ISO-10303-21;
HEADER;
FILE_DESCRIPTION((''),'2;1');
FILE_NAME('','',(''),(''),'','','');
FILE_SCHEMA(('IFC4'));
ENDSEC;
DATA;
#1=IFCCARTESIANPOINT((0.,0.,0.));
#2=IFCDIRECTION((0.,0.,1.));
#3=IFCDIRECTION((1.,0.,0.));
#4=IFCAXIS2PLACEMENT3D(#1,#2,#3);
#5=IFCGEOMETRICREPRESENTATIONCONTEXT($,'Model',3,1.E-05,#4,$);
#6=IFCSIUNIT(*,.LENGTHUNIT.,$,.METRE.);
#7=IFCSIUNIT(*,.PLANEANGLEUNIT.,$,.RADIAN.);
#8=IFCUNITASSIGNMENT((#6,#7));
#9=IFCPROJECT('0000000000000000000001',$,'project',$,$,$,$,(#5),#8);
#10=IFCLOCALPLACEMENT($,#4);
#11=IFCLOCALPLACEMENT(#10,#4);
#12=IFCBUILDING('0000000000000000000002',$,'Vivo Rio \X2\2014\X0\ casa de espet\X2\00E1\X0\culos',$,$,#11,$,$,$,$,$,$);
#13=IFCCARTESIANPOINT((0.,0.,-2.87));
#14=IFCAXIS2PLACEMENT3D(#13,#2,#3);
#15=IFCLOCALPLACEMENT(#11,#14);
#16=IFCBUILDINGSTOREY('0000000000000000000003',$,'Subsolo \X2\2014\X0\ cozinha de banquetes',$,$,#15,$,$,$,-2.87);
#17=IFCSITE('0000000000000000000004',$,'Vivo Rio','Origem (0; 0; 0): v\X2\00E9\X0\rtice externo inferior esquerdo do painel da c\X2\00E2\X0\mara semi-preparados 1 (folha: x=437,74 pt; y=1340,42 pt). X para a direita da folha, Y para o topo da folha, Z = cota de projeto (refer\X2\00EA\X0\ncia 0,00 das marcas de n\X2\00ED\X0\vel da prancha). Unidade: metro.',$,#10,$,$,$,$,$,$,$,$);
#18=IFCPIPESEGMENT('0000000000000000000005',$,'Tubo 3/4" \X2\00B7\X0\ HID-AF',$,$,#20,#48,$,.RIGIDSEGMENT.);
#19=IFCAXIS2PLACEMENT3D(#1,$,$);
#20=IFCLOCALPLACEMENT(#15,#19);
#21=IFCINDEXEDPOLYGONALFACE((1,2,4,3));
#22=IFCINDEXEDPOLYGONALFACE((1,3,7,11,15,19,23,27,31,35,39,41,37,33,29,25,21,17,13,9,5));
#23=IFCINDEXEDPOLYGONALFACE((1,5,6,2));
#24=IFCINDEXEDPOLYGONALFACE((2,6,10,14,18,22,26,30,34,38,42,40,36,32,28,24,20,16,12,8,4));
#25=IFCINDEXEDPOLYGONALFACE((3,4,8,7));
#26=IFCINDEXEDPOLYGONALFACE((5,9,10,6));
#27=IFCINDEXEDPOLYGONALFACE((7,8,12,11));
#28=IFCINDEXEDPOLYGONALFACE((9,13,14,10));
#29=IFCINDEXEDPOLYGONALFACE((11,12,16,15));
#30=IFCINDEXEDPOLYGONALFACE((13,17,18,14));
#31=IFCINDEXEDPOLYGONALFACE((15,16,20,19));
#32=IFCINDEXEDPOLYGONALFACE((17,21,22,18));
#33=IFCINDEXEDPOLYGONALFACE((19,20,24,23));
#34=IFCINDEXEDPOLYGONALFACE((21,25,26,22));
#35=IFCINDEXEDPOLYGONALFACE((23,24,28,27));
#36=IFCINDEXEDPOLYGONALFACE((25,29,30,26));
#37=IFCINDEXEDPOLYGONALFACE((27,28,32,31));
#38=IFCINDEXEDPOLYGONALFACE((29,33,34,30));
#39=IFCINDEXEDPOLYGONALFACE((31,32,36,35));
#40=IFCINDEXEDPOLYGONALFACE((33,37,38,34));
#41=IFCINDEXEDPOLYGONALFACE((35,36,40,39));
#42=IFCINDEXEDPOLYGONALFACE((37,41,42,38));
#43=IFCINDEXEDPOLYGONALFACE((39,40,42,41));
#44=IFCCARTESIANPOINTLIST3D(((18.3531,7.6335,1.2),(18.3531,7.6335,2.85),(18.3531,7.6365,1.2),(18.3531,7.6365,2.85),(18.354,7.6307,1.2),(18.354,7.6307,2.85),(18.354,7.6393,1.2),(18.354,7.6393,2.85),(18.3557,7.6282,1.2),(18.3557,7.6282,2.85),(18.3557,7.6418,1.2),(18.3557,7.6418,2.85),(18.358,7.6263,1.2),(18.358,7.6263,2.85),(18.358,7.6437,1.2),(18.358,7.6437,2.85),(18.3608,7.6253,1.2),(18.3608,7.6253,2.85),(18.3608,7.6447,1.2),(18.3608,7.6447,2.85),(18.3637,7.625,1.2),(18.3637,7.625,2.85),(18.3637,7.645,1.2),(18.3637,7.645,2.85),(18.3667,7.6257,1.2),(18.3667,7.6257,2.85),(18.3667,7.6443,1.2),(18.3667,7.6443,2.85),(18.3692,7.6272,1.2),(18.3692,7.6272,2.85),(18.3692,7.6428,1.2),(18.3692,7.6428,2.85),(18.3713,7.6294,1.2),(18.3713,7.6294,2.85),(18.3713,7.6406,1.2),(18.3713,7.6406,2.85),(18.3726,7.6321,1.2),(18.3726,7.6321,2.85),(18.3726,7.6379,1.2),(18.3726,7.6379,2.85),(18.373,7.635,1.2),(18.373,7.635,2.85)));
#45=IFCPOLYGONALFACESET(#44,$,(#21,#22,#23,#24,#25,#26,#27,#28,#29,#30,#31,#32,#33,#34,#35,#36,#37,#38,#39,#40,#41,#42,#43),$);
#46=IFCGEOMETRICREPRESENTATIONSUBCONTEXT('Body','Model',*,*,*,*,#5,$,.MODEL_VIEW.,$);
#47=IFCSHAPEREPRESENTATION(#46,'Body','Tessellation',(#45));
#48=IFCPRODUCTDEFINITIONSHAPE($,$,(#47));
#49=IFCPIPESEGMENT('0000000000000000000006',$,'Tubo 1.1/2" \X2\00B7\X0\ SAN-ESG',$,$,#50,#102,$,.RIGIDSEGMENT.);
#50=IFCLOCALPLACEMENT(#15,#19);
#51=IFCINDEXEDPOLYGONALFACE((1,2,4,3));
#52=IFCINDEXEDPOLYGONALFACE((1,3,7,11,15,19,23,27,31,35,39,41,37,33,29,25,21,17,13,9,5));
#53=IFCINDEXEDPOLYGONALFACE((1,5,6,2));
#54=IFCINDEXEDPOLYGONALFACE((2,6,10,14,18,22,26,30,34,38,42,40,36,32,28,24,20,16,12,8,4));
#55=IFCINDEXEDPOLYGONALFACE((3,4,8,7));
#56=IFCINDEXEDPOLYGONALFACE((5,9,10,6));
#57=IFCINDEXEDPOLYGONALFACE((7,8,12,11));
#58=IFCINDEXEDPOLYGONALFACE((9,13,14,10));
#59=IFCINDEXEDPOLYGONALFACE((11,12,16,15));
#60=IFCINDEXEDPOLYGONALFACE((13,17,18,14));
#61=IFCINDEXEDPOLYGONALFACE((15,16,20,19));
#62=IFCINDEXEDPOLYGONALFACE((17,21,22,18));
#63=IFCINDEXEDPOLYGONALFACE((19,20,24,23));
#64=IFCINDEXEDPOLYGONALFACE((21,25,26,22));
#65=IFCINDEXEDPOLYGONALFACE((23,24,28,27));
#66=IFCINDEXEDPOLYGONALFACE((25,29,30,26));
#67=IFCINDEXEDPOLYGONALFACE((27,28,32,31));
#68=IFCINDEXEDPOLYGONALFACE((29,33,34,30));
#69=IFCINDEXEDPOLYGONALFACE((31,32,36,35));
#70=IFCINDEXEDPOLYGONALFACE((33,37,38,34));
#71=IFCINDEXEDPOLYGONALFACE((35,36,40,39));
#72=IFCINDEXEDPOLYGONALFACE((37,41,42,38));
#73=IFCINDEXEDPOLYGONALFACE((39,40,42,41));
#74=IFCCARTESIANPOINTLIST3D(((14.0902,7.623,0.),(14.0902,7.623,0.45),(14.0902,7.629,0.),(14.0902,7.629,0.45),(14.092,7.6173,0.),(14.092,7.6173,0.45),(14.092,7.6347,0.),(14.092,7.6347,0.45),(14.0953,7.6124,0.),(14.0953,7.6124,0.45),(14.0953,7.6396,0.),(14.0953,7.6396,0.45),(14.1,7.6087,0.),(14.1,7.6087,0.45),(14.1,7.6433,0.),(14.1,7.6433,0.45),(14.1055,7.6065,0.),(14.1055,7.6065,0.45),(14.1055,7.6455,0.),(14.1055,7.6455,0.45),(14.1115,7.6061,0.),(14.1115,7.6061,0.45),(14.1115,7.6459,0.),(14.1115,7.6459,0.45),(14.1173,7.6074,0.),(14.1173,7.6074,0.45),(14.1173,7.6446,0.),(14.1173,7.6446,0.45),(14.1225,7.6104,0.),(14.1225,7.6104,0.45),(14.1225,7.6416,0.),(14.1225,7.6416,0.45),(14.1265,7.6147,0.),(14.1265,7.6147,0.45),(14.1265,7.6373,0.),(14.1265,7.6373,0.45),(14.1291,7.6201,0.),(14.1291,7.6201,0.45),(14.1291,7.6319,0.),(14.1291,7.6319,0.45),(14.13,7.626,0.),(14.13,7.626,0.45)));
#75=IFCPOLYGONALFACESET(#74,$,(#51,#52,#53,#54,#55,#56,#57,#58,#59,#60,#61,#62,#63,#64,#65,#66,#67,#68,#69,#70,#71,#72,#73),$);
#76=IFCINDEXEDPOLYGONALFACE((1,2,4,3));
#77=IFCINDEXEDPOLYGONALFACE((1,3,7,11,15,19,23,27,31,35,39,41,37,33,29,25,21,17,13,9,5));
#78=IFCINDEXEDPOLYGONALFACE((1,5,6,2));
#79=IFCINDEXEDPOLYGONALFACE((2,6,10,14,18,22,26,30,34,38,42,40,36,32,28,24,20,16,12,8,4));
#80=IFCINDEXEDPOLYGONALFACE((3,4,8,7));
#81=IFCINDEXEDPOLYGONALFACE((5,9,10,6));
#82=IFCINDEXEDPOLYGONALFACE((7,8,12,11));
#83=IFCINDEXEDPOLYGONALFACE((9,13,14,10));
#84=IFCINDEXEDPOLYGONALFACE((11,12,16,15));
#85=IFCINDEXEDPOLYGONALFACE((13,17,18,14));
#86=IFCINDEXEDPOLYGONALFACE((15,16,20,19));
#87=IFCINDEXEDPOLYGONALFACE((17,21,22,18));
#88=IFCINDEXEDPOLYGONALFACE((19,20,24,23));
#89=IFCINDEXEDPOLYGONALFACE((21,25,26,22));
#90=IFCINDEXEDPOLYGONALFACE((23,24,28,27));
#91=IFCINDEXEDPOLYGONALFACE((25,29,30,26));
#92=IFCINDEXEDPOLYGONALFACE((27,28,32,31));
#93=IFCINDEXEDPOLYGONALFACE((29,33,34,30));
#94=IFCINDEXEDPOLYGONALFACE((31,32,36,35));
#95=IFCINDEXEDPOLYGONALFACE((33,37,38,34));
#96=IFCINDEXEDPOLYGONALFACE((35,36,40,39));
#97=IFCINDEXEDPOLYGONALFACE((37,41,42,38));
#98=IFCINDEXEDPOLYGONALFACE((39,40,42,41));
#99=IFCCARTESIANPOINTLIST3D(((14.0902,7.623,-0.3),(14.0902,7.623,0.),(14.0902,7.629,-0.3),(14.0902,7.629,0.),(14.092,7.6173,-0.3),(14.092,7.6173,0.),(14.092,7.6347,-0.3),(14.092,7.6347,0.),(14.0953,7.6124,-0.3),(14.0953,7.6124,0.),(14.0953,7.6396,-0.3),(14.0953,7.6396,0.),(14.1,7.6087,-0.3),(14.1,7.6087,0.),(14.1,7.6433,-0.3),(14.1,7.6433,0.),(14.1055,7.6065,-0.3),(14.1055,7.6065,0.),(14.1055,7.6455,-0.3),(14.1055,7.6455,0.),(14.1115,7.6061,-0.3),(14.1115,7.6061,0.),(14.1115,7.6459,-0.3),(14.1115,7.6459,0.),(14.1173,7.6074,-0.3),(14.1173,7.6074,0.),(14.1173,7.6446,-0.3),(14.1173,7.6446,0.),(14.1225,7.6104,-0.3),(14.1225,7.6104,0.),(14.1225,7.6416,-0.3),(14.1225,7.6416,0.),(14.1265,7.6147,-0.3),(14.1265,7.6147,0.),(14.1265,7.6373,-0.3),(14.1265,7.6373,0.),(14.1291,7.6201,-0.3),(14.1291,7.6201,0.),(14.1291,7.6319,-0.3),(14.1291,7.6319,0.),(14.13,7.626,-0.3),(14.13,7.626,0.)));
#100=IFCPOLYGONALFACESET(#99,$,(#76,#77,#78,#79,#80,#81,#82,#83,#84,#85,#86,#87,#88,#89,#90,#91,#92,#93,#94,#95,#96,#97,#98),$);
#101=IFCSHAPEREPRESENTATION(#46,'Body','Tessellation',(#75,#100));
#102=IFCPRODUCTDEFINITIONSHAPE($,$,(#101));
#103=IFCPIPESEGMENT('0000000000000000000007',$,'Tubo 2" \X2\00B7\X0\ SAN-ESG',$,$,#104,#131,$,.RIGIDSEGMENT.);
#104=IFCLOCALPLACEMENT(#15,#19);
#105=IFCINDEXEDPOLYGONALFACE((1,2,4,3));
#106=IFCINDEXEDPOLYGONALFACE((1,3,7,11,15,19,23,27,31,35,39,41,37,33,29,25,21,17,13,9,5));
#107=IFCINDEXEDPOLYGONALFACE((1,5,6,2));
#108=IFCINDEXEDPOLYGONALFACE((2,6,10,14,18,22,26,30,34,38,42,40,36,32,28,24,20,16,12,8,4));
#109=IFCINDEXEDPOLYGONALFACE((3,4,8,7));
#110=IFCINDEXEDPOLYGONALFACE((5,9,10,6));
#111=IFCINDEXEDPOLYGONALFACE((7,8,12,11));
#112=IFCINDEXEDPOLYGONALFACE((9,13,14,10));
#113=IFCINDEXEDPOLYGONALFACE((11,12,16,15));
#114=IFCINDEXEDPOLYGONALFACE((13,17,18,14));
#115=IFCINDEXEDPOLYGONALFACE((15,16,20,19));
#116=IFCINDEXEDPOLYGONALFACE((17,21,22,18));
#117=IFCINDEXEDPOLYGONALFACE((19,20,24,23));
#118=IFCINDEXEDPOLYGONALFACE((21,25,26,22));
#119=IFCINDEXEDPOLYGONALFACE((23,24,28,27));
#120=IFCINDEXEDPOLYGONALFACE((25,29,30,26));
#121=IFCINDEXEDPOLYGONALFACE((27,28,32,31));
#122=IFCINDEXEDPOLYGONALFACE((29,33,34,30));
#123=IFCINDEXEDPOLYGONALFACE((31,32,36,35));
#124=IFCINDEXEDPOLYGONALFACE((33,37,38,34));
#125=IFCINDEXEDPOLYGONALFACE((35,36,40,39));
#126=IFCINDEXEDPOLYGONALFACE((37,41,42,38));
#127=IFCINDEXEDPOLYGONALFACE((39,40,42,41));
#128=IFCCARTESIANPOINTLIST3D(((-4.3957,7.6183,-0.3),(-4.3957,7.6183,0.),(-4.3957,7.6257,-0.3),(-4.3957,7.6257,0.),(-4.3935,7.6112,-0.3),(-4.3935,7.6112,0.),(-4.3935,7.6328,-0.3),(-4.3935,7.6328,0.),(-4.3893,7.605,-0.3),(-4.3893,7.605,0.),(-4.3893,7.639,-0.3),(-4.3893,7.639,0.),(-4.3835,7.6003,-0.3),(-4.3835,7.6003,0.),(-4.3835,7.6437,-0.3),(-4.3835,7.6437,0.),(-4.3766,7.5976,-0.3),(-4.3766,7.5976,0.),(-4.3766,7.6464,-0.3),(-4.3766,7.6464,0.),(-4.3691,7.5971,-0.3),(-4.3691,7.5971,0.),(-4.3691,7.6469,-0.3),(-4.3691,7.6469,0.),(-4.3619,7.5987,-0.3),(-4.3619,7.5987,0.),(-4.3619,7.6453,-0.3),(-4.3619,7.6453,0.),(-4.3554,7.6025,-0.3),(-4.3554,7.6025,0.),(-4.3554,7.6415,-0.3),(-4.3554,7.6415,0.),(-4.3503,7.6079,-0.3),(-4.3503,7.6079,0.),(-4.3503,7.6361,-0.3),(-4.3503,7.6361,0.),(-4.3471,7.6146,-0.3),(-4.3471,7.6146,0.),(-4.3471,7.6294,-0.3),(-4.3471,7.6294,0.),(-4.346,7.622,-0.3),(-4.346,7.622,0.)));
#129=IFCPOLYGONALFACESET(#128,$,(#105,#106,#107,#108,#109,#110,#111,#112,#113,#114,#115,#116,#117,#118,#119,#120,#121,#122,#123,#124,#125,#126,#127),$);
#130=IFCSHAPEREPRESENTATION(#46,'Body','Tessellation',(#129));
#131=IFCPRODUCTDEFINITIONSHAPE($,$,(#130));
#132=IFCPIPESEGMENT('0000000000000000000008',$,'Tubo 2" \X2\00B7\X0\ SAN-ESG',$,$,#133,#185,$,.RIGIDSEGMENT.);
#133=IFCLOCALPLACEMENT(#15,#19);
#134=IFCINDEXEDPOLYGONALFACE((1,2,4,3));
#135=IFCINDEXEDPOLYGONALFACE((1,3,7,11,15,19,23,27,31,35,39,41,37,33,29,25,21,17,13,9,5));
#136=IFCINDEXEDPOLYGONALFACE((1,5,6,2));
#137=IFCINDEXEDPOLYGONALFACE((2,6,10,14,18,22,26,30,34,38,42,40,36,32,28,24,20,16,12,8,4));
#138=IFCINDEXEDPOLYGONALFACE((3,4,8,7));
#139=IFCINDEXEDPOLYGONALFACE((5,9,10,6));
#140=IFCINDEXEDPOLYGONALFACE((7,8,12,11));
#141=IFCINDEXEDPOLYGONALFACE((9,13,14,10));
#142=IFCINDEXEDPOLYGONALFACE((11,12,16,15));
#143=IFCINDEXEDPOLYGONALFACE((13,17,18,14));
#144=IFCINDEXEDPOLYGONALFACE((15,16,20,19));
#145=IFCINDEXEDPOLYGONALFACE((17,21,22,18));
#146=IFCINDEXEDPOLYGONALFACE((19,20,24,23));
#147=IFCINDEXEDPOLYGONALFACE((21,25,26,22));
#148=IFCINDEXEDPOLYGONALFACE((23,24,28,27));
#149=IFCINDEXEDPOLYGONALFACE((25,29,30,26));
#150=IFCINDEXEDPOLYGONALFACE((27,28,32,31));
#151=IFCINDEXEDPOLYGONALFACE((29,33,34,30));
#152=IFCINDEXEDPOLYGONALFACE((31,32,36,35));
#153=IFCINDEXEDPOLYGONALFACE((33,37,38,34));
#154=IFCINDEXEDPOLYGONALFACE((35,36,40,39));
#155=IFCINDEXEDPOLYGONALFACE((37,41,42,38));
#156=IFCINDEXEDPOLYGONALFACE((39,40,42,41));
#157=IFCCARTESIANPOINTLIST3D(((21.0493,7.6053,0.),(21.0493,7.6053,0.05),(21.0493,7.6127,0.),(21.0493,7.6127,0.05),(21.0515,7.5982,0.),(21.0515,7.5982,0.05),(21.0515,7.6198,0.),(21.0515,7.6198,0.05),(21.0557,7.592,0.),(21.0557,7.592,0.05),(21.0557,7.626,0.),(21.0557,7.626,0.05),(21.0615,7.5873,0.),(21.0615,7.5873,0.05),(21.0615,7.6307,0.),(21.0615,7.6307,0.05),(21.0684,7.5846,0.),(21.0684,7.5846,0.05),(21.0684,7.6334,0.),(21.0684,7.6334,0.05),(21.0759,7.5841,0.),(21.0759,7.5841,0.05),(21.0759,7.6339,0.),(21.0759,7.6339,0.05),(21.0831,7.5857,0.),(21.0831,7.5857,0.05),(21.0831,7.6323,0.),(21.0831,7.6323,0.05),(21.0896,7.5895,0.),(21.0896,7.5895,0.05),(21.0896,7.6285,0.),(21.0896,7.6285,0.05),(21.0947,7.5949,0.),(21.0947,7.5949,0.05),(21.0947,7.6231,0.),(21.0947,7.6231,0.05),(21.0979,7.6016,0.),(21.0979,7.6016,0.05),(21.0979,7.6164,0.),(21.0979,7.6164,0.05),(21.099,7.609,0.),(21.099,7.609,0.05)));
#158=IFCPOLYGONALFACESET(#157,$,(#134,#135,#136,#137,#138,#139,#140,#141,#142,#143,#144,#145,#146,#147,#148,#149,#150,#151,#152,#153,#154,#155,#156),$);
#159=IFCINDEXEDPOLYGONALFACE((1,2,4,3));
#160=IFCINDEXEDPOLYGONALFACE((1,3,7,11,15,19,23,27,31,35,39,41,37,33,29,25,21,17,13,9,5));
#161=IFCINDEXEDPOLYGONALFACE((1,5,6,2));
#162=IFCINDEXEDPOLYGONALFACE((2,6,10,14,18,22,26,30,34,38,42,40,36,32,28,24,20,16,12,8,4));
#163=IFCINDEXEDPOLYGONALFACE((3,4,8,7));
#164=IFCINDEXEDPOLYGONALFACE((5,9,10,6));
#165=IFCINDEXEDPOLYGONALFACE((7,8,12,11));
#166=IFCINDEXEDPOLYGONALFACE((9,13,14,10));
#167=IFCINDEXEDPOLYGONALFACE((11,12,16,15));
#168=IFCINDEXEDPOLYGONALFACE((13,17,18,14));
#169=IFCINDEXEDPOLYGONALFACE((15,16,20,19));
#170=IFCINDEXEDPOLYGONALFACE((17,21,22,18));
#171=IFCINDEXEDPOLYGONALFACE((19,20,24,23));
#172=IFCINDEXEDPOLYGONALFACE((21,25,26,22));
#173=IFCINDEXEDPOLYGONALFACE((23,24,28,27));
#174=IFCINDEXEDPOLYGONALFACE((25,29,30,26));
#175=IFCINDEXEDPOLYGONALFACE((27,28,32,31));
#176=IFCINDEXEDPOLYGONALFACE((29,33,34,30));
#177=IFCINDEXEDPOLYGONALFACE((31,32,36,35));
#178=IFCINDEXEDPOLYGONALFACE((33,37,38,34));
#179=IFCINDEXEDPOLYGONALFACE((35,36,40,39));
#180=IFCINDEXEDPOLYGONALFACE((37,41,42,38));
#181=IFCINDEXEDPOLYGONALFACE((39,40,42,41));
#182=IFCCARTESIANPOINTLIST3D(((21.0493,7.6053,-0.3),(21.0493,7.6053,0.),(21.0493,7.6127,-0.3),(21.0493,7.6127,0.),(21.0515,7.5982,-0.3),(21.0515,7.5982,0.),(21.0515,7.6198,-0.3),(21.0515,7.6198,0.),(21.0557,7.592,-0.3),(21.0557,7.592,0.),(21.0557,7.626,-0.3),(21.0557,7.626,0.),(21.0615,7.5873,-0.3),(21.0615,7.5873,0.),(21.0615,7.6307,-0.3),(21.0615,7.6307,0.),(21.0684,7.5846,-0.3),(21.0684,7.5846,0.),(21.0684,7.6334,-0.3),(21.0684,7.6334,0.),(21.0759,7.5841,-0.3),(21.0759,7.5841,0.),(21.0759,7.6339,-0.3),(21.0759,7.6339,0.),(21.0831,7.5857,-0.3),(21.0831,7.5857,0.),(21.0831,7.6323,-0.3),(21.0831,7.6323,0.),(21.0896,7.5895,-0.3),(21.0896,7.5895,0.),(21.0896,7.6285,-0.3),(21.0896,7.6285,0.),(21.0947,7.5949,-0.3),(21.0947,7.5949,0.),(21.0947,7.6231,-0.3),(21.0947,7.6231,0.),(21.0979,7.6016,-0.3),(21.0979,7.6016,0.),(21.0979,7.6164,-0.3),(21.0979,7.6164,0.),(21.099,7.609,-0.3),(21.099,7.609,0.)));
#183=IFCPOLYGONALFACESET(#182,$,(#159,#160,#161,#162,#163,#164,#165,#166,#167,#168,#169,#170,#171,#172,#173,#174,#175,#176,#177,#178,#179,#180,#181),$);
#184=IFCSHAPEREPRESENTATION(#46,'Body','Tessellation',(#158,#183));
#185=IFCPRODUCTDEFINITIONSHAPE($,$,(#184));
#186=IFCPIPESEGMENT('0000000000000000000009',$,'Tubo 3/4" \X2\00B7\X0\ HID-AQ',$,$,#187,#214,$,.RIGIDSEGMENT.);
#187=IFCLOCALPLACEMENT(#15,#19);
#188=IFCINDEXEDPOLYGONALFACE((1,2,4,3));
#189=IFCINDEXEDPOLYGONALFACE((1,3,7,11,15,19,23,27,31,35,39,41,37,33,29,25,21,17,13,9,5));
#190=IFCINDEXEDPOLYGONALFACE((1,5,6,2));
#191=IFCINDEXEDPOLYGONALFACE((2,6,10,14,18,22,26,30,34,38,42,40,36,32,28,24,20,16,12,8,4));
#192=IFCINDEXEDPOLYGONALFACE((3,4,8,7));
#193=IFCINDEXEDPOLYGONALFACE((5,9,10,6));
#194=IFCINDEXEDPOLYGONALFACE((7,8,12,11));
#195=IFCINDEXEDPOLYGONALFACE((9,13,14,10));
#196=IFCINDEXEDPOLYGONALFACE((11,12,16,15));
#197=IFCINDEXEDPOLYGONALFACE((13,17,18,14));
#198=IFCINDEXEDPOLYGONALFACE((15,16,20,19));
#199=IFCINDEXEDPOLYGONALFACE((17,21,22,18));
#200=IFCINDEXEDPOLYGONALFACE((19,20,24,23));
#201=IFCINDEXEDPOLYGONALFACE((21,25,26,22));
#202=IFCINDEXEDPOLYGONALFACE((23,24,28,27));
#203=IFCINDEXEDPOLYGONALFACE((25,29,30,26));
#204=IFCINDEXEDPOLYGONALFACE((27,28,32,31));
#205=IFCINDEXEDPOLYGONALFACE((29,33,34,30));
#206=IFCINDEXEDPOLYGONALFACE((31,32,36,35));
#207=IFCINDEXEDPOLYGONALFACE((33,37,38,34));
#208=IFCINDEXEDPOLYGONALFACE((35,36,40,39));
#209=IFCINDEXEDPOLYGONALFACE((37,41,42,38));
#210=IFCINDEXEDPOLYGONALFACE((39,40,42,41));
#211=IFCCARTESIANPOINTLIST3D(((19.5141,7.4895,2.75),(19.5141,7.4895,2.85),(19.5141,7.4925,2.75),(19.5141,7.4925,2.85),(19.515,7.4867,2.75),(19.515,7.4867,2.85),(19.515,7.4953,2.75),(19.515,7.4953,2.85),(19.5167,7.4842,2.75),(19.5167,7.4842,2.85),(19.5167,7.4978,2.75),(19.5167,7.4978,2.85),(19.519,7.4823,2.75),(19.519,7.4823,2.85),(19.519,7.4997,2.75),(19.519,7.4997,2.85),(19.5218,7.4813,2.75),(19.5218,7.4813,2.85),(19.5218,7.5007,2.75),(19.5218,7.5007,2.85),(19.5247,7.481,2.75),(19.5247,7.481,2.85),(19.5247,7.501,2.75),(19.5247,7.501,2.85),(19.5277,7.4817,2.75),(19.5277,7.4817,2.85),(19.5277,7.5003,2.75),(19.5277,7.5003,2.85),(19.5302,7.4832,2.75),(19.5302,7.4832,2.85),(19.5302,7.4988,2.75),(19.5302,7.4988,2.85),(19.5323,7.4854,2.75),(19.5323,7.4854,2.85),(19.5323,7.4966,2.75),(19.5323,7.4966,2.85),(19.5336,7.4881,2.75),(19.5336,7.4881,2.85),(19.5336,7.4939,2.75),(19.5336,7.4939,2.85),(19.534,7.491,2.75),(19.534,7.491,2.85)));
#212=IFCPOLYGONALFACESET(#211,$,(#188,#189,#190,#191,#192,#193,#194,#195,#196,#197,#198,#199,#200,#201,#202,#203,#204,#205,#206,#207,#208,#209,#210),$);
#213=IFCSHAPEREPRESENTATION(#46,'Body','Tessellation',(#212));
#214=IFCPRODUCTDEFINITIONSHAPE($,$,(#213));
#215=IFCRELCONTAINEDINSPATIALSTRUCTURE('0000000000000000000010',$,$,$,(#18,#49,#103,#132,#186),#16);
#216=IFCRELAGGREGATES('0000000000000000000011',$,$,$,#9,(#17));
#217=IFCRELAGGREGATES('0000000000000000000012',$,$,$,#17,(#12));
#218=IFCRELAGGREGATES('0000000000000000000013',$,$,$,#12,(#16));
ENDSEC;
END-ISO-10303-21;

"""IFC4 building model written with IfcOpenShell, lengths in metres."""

from ifc_helpers import new_model, si_unit, frame, origin_with_axes, origin_2d, place, context, subcontext, project, spatial, circle, extrude, element, save


model = new_model("IFC4")

# Units and contexts
model_context = context("Model", 3, precision=1e-05, world=origin_with_axes())
body_context = subcontext(model_context, "Body", "Model", "MODEL_VIEW")
ifc_project = project(units=[si_unit("LENGTHUNIT", "METRE"), si_unit("PLANEANGLEUNIT", "RADIAN")], contexts=[model_context])

# Site, building, storey
site_placement = place(None, origin_with_axes())
site = spatial("IfcSite", under=ifc_project, at=site_placement, Name="Vivo Rio", Description="Origem (0; 0; 0): vértice externo inferior esquerdo do painel da câmara semi-preparados 1 (folha: x=437,74 pt; y=1340,42 pt). X para a direita da folha, Y para o topo da folha, Z = cota de projeto (referência 0,00 das marcas de nível da prancha). Unidade: metro.")
building_placement = place(site_placement, origin_with_axes())
building = spatial("IfcBuilding", under=site, at=building_placement, Name="Vivo Rio — casa de espetáculos")
storey_placement = place(building_placement, frame((0.0, 0.0, -2.87), z_axis=(0.0, 0.0, 1.0), x_axis=(1.0, 0.0, 0.0)))
storey = spatial("IfcBuildingStorey", under=building, at=storey_placement, Name="Subsolo — cozinha de banquetes", Elevation=-2.87)

# Pipe segments
pipe_segment_1_placement = place(storey_placement, origin_with_axes())
element("IfcPipeSegment", 1, at=pipe_segment_1_placement, inside=storey, Name="Tubo 3/4\" · HID-AF", PredefinedType="RIGIDSEGMENT", context=body_context, shape_type="SweptSolid", body=[
    extrude(circle(Radius=0.01, at=origin_2d()), frame((18.363, 7.635, 2.85), z_axis=(0.0, 0.0, -1.0), x_axis=(1.0, 0.0, 0.0)), (0.0, 0.0, 1.0), 1.65),
])
pipe_segment_2_placement = place(storey_placement, origin_with_axes())
element("IfcPipeSegment", 2, at=pipe_segment_2_placement, inside=storey, Name="Tubo 1.1/2\" · SAN-ESG", PredefinedType="RIGIDSEGMENT", context=body_context, shape_type="SweptSolid", body=[
    extrude(circle(Radius=0.02, at=origin_2d()), frame((14.11, 7.626, 0.45), z_axis=(0.0, 0.0, -1.0), x_axis=(1.0, 0.0, 0.0)), (0.0, 0.0, 1.0), 0.45),
    extrude(circle(Radius=0.02, at=origin_2d()), frame((14.11, 7.626, 0.0), z_axis=(0.0, 0.0, -1.0), x_axis=(1.0, 0.0, 0.0)), (0.0, 0.0, 1.0), 0.3),
])
pipe_segment_3_placement = place(storey_placement, origin_with_axes())
element("IfcPipeSegment", 3, at=pipe_segment_3_placement, inside=storey, Name="Tubo 2\" · SAN-ESG", PredefinedType="RIGIDSEGMENT", context=body_context, shape_type="SweptSolid", body=[
    extrude(circle(Radius=0.025, at=origin_2d()), frame((-4.371, 7.622, 0.0), z_axis=(0.0, 0.0, -1.0), x_axis=(1.0, 0.0, 0.0)), (0.0, 0.0, 1.0), 0.3),
])
pipe_segment_4_placement = place(storey_placement, origin_with_axes())
element("IfcPipeSegment", 4, at=pipe_segment_4_placement, inside=storey, Name="Tubo 2\" · SAN-ESG", PredefinedType="RIGIDSEGMENT", context=body_context, shape_type="SweptSolid", body=[
    extrude(circle(Radius=0.025, at=origin_2d()), frame((21.074, 7.609, 0.05), z_axis=(0.0, 0.0, -1.0), x_axis=(1.0, 0.0, 0.0)), (0.0, 0.0, 1.0), 0.05),
    extrude(circle(Radius=0.025, at=origin_2d()), frame((21.074, 7.609, 0.0), z_axis=(0.0, 0.0, -1.0), x_axis=(1.0, 0.0, 0.0)), (0.0, 0.0, 1.0), 0.3),
])
pipe_segment_5_placement = place(storey_placement, origin_with_axes())
element("IfcPipeSegment", 5, at=pipe_segment_5_placement, inside=storey, Name="Tubo 3/4\" · HID-AQ", PredefinedType="RIGIDSEGMENT", context=body_context, shape_type="SweptSolid", body=[
    extrude(circle(Radius=0.01, at=origin_2d()), frame((19.524, 7.491, 2.85), z_axis=(0.0, 0.0, -1.0), x_axis=(1.0, 0.0, 0.0)), (0.0, 0.0, 1.0), 0.1),
])

save(model, "model.ifc")
